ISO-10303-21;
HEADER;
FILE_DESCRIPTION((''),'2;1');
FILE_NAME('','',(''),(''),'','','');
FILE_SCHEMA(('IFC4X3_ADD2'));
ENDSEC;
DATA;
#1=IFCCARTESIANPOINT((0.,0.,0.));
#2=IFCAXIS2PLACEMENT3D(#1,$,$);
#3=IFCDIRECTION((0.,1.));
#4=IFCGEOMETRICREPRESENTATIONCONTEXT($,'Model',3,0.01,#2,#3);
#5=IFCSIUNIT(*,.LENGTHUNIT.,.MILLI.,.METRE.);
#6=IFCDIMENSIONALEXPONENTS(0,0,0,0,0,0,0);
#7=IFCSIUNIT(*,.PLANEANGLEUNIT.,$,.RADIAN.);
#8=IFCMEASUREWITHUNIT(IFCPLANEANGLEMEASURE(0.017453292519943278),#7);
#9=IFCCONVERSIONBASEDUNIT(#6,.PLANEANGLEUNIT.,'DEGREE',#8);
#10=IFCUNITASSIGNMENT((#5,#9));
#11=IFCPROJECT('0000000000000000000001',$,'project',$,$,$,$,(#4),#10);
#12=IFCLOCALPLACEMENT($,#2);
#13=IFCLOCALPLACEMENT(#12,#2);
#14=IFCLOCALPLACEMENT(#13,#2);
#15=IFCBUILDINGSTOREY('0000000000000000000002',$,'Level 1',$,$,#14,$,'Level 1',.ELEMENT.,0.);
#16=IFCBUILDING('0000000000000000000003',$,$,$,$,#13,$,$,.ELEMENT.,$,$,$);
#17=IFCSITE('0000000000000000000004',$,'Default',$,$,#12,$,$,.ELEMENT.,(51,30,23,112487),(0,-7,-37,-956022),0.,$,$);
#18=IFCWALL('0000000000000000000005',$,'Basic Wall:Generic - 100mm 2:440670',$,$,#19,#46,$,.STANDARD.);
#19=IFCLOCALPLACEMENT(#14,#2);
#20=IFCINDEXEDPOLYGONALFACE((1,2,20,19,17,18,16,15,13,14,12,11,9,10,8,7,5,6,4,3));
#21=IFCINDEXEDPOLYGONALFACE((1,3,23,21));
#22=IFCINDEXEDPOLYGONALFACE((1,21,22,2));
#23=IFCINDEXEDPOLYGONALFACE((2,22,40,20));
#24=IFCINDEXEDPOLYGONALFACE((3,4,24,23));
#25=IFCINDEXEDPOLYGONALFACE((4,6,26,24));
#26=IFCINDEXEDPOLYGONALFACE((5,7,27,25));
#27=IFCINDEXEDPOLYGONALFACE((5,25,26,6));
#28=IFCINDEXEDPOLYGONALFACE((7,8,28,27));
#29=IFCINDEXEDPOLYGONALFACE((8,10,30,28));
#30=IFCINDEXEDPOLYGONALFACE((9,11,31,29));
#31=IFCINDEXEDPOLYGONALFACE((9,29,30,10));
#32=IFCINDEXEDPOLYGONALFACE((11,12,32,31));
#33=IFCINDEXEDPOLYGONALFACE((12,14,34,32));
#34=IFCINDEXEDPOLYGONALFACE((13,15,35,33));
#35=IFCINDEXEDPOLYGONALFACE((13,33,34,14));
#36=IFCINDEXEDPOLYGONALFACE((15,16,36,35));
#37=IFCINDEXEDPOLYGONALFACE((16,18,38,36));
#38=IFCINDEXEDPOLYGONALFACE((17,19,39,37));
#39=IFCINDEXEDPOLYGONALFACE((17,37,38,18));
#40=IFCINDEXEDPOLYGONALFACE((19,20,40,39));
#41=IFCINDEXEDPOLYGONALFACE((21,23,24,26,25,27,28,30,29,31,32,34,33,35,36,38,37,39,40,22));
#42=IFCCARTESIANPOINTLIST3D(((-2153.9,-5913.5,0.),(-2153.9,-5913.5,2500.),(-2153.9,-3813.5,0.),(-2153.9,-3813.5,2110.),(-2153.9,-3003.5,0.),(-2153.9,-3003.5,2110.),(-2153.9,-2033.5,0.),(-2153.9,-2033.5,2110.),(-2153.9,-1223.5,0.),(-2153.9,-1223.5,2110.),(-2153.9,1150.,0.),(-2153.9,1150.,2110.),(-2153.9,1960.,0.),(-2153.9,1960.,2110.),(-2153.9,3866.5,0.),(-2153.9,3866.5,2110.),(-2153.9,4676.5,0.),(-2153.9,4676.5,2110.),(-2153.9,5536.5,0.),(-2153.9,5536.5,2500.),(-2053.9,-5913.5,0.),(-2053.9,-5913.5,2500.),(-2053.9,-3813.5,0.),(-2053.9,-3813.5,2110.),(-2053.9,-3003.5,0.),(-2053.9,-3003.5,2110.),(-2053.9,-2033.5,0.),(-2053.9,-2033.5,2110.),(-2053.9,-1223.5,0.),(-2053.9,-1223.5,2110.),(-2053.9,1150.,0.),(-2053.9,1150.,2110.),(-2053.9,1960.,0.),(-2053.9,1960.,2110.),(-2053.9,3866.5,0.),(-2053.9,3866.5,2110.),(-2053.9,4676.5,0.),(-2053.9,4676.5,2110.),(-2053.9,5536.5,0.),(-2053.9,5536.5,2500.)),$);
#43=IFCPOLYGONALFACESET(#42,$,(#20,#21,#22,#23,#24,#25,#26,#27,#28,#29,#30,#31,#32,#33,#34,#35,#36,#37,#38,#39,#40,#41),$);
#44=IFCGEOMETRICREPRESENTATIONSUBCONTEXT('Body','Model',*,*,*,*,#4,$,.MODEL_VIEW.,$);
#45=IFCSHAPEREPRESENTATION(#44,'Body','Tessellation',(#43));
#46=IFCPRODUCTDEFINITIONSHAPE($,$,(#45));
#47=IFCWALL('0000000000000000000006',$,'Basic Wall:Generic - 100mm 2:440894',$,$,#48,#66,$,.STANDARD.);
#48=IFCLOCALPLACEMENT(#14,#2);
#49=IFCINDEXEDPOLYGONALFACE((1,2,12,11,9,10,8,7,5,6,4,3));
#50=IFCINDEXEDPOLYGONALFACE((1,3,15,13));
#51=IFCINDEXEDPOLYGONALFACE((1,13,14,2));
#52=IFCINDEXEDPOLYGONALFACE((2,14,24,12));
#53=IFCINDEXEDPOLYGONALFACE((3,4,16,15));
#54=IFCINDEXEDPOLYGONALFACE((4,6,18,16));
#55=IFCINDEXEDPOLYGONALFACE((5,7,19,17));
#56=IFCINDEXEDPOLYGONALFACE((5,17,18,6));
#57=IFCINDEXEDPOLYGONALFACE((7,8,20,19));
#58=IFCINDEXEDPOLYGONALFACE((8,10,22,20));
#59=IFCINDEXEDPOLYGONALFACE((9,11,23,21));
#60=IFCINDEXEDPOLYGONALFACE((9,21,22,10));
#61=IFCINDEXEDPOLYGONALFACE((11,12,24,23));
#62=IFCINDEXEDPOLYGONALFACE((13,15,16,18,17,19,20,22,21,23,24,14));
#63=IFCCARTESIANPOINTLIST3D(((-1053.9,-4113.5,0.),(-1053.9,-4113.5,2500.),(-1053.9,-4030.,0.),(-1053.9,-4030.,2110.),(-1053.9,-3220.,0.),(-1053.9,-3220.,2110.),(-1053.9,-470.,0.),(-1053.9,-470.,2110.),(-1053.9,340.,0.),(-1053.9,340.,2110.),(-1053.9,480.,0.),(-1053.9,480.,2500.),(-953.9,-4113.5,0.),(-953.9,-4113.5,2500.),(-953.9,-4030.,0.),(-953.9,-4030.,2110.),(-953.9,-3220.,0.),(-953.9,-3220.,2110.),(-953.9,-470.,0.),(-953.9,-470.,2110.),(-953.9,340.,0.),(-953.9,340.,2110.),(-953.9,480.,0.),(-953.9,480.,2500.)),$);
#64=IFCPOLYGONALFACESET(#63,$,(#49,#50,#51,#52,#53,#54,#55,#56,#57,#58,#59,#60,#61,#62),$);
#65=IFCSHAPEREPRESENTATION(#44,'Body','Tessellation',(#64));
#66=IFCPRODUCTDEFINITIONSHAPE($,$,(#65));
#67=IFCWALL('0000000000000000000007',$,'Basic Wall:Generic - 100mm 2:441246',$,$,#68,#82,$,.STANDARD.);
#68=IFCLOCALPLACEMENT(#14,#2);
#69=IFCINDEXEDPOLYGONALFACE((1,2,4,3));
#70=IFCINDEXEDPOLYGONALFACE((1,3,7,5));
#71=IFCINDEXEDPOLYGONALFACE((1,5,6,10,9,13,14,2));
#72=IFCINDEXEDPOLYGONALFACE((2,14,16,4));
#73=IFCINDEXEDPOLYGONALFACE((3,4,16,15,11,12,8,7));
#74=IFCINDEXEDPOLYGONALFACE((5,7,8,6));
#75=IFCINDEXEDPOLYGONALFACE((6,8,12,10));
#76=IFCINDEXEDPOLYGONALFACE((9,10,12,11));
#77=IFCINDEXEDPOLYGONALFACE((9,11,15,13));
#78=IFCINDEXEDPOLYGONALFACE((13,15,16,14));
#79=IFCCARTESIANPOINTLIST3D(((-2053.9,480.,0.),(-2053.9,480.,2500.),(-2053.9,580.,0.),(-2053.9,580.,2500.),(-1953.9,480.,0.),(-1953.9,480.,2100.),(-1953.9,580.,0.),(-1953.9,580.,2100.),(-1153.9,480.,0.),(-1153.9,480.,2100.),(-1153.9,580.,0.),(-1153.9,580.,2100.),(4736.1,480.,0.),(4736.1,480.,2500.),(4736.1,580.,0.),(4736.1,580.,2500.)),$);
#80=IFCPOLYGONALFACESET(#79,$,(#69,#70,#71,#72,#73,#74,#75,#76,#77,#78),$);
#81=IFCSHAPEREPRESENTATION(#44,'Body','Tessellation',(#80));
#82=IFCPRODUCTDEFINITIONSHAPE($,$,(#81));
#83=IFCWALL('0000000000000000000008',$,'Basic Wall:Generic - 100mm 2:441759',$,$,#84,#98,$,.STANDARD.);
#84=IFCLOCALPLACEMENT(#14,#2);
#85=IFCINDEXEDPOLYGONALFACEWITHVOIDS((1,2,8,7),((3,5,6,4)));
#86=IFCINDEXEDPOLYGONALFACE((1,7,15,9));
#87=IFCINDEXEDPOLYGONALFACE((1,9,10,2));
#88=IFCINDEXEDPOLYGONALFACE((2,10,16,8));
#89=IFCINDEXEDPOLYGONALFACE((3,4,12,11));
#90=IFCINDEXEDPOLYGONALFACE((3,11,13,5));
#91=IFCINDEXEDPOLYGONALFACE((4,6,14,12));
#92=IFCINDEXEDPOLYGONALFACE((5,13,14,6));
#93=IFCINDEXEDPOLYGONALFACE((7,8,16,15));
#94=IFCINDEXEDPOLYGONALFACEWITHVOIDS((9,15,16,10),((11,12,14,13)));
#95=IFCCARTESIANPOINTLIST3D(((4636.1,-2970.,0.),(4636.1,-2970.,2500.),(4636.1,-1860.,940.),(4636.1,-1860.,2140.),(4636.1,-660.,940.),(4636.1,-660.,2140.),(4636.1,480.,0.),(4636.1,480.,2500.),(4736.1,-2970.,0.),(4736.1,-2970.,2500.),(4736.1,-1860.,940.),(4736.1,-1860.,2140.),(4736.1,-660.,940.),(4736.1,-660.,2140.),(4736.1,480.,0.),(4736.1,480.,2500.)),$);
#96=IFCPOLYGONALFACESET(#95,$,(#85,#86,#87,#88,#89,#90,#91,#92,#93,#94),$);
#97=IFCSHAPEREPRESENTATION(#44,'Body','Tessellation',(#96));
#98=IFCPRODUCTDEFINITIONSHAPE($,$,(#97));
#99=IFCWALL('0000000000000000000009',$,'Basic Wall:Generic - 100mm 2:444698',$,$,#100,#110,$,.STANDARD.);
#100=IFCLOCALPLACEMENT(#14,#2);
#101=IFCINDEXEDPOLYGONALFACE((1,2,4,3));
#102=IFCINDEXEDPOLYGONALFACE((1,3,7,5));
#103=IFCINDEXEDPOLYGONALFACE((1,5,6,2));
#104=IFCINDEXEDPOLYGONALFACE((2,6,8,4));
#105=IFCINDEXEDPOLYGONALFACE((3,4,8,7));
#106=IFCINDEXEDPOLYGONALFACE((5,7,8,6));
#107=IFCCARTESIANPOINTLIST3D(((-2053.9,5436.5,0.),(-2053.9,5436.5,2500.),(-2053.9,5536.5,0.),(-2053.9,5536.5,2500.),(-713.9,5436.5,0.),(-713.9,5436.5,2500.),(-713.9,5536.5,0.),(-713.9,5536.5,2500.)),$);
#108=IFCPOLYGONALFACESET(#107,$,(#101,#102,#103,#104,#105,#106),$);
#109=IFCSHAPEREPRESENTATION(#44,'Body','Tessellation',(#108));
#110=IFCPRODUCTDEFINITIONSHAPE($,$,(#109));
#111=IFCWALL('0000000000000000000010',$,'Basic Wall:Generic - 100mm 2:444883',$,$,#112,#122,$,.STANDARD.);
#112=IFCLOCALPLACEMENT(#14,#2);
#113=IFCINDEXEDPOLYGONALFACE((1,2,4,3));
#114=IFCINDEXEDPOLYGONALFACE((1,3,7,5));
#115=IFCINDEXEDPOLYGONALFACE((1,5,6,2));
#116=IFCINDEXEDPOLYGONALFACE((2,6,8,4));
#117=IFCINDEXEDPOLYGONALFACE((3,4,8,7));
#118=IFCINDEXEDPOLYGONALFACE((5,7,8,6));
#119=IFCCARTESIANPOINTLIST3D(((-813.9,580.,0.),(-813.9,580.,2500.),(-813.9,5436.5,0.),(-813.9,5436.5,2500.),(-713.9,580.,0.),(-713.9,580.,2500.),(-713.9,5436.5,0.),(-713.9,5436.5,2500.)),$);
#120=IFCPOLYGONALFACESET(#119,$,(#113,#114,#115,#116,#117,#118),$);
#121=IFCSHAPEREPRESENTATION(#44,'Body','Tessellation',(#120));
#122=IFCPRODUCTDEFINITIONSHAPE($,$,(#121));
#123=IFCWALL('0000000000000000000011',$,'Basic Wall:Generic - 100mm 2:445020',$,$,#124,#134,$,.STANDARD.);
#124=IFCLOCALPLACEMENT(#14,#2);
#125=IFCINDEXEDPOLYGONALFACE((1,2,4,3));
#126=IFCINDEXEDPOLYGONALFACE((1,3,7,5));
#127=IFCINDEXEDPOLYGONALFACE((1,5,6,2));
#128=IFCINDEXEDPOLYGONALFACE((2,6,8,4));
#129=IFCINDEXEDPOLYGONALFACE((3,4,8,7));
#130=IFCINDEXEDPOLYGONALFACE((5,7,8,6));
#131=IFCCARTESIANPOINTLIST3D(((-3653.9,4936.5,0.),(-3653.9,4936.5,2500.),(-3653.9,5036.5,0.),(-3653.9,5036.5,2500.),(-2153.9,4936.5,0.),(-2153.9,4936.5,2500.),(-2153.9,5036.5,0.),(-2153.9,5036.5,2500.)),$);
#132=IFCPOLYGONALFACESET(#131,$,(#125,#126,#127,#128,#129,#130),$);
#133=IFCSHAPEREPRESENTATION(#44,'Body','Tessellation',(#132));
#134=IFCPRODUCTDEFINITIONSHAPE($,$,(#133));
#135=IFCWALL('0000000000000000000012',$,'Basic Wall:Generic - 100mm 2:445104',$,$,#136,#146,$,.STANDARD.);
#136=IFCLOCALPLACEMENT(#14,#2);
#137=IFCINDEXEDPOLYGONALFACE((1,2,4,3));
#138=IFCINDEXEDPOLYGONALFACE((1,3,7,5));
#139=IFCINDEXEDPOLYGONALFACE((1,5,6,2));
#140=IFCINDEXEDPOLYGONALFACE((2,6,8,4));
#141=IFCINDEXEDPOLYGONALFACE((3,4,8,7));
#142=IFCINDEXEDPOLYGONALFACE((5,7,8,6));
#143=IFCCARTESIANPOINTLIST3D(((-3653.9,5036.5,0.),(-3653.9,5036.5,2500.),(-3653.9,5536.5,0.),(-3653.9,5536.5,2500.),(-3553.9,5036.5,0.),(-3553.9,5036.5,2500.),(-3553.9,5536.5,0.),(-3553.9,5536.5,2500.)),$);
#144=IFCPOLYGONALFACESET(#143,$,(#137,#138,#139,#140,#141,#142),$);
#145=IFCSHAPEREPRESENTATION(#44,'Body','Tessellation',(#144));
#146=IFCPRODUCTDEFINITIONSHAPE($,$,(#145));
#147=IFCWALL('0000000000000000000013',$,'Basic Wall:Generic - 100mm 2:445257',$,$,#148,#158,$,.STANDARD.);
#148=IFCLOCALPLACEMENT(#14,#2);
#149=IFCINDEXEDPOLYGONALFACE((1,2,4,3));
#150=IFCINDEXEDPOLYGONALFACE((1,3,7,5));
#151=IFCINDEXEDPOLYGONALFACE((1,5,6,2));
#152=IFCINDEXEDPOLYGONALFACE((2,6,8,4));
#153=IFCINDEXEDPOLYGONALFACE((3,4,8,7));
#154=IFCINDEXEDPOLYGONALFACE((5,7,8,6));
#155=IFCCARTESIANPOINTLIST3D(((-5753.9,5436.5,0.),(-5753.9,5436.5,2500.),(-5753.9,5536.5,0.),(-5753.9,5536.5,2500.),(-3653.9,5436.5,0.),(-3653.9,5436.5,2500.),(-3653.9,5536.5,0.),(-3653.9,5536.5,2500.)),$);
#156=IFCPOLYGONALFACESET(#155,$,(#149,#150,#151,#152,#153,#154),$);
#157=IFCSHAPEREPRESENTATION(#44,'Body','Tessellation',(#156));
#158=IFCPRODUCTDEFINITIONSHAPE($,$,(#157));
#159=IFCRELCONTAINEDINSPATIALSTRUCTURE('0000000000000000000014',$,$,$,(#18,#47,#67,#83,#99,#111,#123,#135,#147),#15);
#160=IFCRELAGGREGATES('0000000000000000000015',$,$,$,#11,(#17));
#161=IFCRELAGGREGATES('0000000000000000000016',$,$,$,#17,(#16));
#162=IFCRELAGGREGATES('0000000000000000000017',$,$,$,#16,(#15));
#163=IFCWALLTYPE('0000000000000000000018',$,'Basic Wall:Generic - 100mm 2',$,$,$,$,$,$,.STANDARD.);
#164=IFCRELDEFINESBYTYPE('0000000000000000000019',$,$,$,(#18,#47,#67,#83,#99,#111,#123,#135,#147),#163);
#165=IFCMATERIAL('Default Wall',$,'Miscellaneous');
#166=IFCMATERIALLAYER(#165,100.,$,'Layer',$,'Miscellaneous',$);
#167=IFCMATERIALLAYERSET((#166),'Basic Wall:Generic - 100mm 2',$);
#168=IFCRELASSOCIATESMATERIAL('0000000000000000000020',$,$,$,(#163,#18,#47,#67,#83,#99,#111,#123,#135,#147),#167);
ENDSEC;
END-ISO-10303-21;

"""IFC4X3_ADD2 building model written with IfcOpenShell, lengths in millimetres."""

from ifc_helpers import new_model, entity, si_unit, converted_unit, direction, frame, frame_2d, origin, place, context, subcontext, project, spatial, rectangle, extrude, material, layer, layer_set, type_object, element, save


model = new_model("IFC4X3_ADD2")

# Units and contexts
model_context = context("Model", 3, precision=0.01, world=origin(), true_north=direction((0.0, 1.0)))
body_context = subcontext(model_context, "Body", "Model", "MODEL_VIEW")
ifc_project = project(units=[si_unit("LENGTHUNIT", "METRE", prefix="MILLI"), converted_unit("PLANEANGLEUNIT", "DEGREE", entity("IfcPlaneAngleMeasure", 0.017453292519943278), si_unit("PLANEANGLEUNIT", "RADIAN"), dimensions=[0, 0, 0, 0, 0, 0, 0])], contexts=[model_context])

# Site, building, storey
site_placement = place(None, origin())
site = spatial("IfcSite", under=ifc_project, at=site_placement, Name="Default", CompositionType="ELEMENT", RefLatitude=(51, 30, 23, 112487), RefLongitude=(0, -7, -37, -956022), RefElevation=0.0)
building_placement = place(site_placement, origin())
building = spatial("IfcBuilding", under=site, at=building_placement, CompositionType="ELEMENT")
storey_placement = place(building_placement, origin())
storey = spatial("IfcBuildingStorey", under=building, at=storey_placement, Name="Level 1", LongName="Level 1", CompositionType="ELEMENT", Elevation=0.0)

# Walls, openings
ifc_material_1 = material(Name="Default Wall", Category="Miscellaneous")
ifc_layer_1 = layer(ifc_material_1, 100.0, Name="Layer", Category="Miscellaneous")
ifc_layer_set_1 = layer_set([ifc_layer_1], Name="Basic Wall:Generic - 100mm 2")
wall_type = type_object("IfcWallType", Name="Basic Wall:Generic - 100mm 2", PredefinedType="STANDARD", material=ifc_layer_set_1)
wall_1_placement = place(storey_placement, frame((-2103.9, 5536.5, 0.0), z_axis=(0.0, 0.0, 1.0), x_axis=(0.0, -1.0, 0.0)))
wall_1 = element("IfcWall", 1, at=wall_1_placement, inside=storey, type_object=wall_type, material=ifc_layer_set_1, Name="Basic Wall:Generic - 100mm 2:440670", PredefinedType="STANDARD", context=body_context, shape_type="SweptSolid", body=[
    extrude(rectangle(XDim=11450.0, YDim=100.0, at=frame_2d((5725.0, 0.0), x_axis=(1.0, 0.0))), origin(), (0.0, 0.0, 1.0), 2500.0),
])
opening_1_placement = place(wall_1_placement, frame((4386.4, 50.0, 0.0)))
element("IfcOpeningElement", 2, at=opening_1_placement, cuts=wall_1, PredefinedType="OPENING", context=body_context, shape_type="SweptSolid", body=[
    extrude(rectangle(XDim=2110.0, YDim=810.0, at=frame_2d((1055.0, 405.0), x_axis=(1.0, 0.0))), frame((0.0, 0.0, 0.0), z_axis=(0.0, -1.0, 0.0), x_axis=(0.0, 0.0, 1.0)), (0.0, 0.0, 1.0), 100.0),
])
opening_2_placement = place(wall_1_placement, frame((6760.0, -50.0, 0.0)))
element("IfcOpeningElement", 3, at=opening_2_placement, cuts=wall_1, PredefinedType="OPENING", context=body_context, shape_type="SweptSolid", body=[
    extrude(rectangle(XDim=2110.0, YDim=810.0, at=frame_2d((1055.0, 405.0), x_axis=(1.0, 0.0))), frame((0.0, 0.0, 0.0), z_axis=(0.0, 1.0, 0.0), x_axis=(0.0, 0.0, 1.0)), (0.0, 0.0, 1.0), 100.0),
])
opening_3_placement = place(wall_1_placement, frame((8540.0, -50.0, 0.0)))
element("IfcOpeningElement", 4, at=opening_3_placement, cuts=wall_1, PredefinedType="OPENING", context=body_context, shape_type="SweptSolid", body=[
    extrude(rectangle(XDim=2110.0, YDim=810.0, at=frame_2d((1055.0, 405.0), x_axis=(1.0, 0.0))), frame((0.0, 0.0, 0.0), z_axis=(0.0, 1.0, 0.0), x_axis=(0.0, 0.0, 1.0)), (0.0, 0.0, 1.0), 100.0),
])
opening_4_placement = place(wall_1_placement, frame((860.0, -50.0, 0.0)))
element("IfcOpeningElement", 5, at=opening_4_placement, cuts=wall_1, PredefinedType="OPENING", context=body_context, shape_type="SweptSolid", body=[
    extrude(rectangle(XDim=2110.0, YDim=810.0, at=frame_2d((1055.0, 405.0), x_axis=(1.0, 0.0))), frame((0.0, 0.0, 0.0), z_axis=(0.0, 1.0, 0.0), x_axis=(0.0, 0.0, 1.0)), (0.0, 0.0, 1.0), 100.0),
])
wall_2_placement = place(storey_placement, frame((-1003.9, 480.0, 0.0), z_axis=(0.0, 0.0, 1.0), x_axis=(0.0, -1.0, 0.0)))
wall_2 = element("IfcWall", 6, at=wall_2_placement, inside=storey, type_object=wall_type, material=ifc_layer_set_1, Name="Basic Wall:Generic - 100mm 2:440894", PredefinedType="STANDARD", context=body_context, shape_type="SweptSolid", body=[
    extrude(rectangle(XDim=4593.6, YDim=100.0, at=frame_2d((2296.8, 0.0), x_axis=(-1.0, 0.0))), origin(), (0.0, 0.0, 1.0), 2500.0),
])
opening_5_placement = place(wall_2_placement, frame((140.0, -50.0, 0.0)))
element("IfcOpeningElement", 7, at=opening_5_placement, cuts=wall_2, PredefinedType="OPENING", context=body_context, shape_type="SweptSolid", body=[
    extrude(rectangle(XDim=2110.0, YDim=810.0, at=frame_2d((1055.0, 405.0), x_axis=(1.0, 0.0))), frame((0.0, 0.0, 0.0), z_axis=(0.0, 1.0, 0.0), x_axis=(0.0, 0.0, 1.0)), (0.0, 0.0, 1.0), 100.0),
])
opening_6_placement = place(wall_2_placement, frame((3700.0, -50.0, 0.0)))
element("IfcOpeningElement", 8, at=opening_6_placement, cuts=wall_2, PredefinedType="OPENING", context=body_context, shape_type="SweptSolid", body=[
    extrude(rectangle(XDim=2110.0, YDim=810.0, at=frame_2d((1055.0, 405.0), x_axis=(1.0, 0.0))), frame((0.0, 0.0, 0.0), z_axis=(0.0, 1.0, 0.0), x_axis=(0.0, 0.0, 1.0)), (0.0, 0.0, 1.0), 100.0),
])

# Walls, openings
wall_3_placement = place(storey_placement, frame((-2053.9, 530.0, 0.0)))
wall_3 = element("IfcWall", 9, at=wall_3_placement, inside=storey, type_object=wall_type, material=ifc_layer_set_1, Name="Basic Wall:Generic - 100mm 2:441246", PredefinedType="STANDARD", context=body_context, shape_type="SweptSolid", body=[
    extrude(rectangle(XDim=6790.0, YDim=100.0, at=frame_2d((3395.0, 0.0), x_axis=(1.0, 0.0))), origin(), (0.0, 0.0, 1.0), 2500.0),
])
opening_7_placement = place(wall_3_placement, frame((100.0, -50.0, 0.0)))
element("IfcOpeningElement", 10, at=opening_7_placement, cuts=wall_3, PredefinedType="OPENING", context=body_context, shape_type="SweptSolid", body=[
    extrude(rectangle(XDim=2100.0, YDim=800.0, at=frame_2d((0.0, 0.0), x_axis=(1.0, 0.0))), frame((400.0, 0.0, 1050.0), z_axis=(0.0, 1.0, 0.0), x_axis=(0.0, 0.0, -1.0)), (0.0, 0.0, 1.0), 100.0),
])
wall_4_placement = place(storey_placement, frame((4686.1, 480.0, 0.0), z_axis=(0.0, 0.0, 1.0), x_axis=(0.0, -1.0, 0.0)))
wall_4 = element("IfcWall", 11, at=wall_4_placement, inside=storey, type_object=wall_type, material=ifc_layer_set_1, Name="Basic Wall:Generic - 100mm 2:441759", PredefinedType="STANDARD", context=body_context, shape_type="SweptSolid", body=[
    extrude(rectangle(XDim=3450.0, YDim=100.0, at=frame_2d((1725.0, 0.0), x_axis=(-1.0, 0.0))), origin(), (0.0, 0.0, 1.0), 2500.0),
])
opening_8_placement = place(wall_4_placement, frame((1140.0, -50.0, 940.0)))
element("IfcOpeningElement", 12, at=opening_8_placement, cuts=wall_4, PredefinedType="OPENING", context=body_context, shape_type="SweptSolid", body=[
    extrude(rectangle(XDim=1200.0, YDim=1200.0, at=frame_2d((600.0, 600.0), x_axis=(-1.0, 0.0))), frame((0.0, 0.0, 0.0), z_axis=(0.0, 1.0, 0.0), x_axis=(0.0, 0.0, 1.0)), (0.0, 0.0, 1.0), 100.0),
])

# Walls
wall_5_placement = place(storey_placement, frame((-2053.9, 5486.5, 0.0)))
element("IfcWall", 13, at=wall_5_placement, inside=storey, type_object=wall_type, material=ifc_layer_set_1, Name="Basic Wall:Generic - 100mm 2:444698", PredefinedType="STANDARD", context=body_context, shape_type="SweptSolid", body=[
    extrude(rectangle(XDim=1340.0, YDim=100.0, at=frame_2d((670.0, 0.0), x_axis=(-1.0, 0.0))), origin(), (0.0, 0.0, 1.0), 2500.0),
])
wall_6_placement = place(storey_placement, frame((-763.9, 5436.5, 0.0), z_axis=(0.0, 0.0, 1.0), x_axis=(0.0, -1.0, 0.0)))
element("IfcWall", 14, at=wall_6_placement, inside=storey, type_object=wall_type, material=ifc_layer_set_1, Name="Basic Wall:Generic - 100mm 2:444883", PredefinedType="STANDARD", context=body_context, shape_type="SweptSolid", body=[
    extrude(rectangle(XDim=4856.4, YDim=100.0, at=frame_2d((2428.2, 0.0), x_axis=(-1.0, 0.0))), origin(), (0.0, 0.0, 1.0), 2500.0),
])
wall_7_placement = place(storey_placement, frame((-2153.9, 4986.5, 0.0), z_axis=(0.0, 0.0, 1.0), x_axis=(-1.0, 0.0, 0.0)))
element("IfcWall", 15, at=wall_7_placement, inside=storey, type_object=wall_type, material=ifc_layer_set_1, Name="Basic Wall:Generic - 100mm 2:445020", PredefinedType="STANDARD", context=body_context, shape_type="SweptSolid", body=[
    extrude(rectangle(XDim=1500.0, YDim=100.0, at=frame_2d((750.0, 0.0), x_axis=(-1.0, 0.0))), origin(), (0.0, 0.0, 1.0), 2500.0),
])
wall_8_placement = place(storey_placement, frame((-3603.9, 5036.5, 0.0), z_axis=(0.0, 0.0, 1.0), x_axis=(0.0, 1.0, 0.0)))
element("IfcWall", 16, at=wall_8_placement, inside=storey, type_object=wall_type, material=ifc_layer_set_1, Name="Basic Wall:Generic - 100mm 2:445104", PredefinedType="STANDARD", context=body_context, shape_type="SweptSolid", body=[
    extrude(rectangle(XDim=500.0, YDim=100.0, at=frame_2d((250.0, 0.0), x_axis=(-1.0, 0.0))), origin(), (0.0, 0.0, 1.0), 2500.0),
])
wall_9_placement = place(storey_placement, frame((-3653.9, 5486.5, 0.0), z_axis=(0.0, 0.0, 1.0), x_axis=(-1.0, 0.0, 0.0)))
element("IfcWall", 17, at=wall_9_placement, inside=storey, type_object=wall_type, material=ifc_layer_set_1, Name="Basic Wall:Generic - 100mm 2:445257", PredefinedType="STANDARD", context=body_context, shape_type="SweptSolid", body=[
    extrude(rectangle(XDim=2100.0, YDim=100.0, at=frame_2d((1050.0, 0.0), x_axis=(-1.0, 0.0))), origin(), (0.0, 0.0, 1.0), 2500.0),
])

save(model, "model.ifc")
